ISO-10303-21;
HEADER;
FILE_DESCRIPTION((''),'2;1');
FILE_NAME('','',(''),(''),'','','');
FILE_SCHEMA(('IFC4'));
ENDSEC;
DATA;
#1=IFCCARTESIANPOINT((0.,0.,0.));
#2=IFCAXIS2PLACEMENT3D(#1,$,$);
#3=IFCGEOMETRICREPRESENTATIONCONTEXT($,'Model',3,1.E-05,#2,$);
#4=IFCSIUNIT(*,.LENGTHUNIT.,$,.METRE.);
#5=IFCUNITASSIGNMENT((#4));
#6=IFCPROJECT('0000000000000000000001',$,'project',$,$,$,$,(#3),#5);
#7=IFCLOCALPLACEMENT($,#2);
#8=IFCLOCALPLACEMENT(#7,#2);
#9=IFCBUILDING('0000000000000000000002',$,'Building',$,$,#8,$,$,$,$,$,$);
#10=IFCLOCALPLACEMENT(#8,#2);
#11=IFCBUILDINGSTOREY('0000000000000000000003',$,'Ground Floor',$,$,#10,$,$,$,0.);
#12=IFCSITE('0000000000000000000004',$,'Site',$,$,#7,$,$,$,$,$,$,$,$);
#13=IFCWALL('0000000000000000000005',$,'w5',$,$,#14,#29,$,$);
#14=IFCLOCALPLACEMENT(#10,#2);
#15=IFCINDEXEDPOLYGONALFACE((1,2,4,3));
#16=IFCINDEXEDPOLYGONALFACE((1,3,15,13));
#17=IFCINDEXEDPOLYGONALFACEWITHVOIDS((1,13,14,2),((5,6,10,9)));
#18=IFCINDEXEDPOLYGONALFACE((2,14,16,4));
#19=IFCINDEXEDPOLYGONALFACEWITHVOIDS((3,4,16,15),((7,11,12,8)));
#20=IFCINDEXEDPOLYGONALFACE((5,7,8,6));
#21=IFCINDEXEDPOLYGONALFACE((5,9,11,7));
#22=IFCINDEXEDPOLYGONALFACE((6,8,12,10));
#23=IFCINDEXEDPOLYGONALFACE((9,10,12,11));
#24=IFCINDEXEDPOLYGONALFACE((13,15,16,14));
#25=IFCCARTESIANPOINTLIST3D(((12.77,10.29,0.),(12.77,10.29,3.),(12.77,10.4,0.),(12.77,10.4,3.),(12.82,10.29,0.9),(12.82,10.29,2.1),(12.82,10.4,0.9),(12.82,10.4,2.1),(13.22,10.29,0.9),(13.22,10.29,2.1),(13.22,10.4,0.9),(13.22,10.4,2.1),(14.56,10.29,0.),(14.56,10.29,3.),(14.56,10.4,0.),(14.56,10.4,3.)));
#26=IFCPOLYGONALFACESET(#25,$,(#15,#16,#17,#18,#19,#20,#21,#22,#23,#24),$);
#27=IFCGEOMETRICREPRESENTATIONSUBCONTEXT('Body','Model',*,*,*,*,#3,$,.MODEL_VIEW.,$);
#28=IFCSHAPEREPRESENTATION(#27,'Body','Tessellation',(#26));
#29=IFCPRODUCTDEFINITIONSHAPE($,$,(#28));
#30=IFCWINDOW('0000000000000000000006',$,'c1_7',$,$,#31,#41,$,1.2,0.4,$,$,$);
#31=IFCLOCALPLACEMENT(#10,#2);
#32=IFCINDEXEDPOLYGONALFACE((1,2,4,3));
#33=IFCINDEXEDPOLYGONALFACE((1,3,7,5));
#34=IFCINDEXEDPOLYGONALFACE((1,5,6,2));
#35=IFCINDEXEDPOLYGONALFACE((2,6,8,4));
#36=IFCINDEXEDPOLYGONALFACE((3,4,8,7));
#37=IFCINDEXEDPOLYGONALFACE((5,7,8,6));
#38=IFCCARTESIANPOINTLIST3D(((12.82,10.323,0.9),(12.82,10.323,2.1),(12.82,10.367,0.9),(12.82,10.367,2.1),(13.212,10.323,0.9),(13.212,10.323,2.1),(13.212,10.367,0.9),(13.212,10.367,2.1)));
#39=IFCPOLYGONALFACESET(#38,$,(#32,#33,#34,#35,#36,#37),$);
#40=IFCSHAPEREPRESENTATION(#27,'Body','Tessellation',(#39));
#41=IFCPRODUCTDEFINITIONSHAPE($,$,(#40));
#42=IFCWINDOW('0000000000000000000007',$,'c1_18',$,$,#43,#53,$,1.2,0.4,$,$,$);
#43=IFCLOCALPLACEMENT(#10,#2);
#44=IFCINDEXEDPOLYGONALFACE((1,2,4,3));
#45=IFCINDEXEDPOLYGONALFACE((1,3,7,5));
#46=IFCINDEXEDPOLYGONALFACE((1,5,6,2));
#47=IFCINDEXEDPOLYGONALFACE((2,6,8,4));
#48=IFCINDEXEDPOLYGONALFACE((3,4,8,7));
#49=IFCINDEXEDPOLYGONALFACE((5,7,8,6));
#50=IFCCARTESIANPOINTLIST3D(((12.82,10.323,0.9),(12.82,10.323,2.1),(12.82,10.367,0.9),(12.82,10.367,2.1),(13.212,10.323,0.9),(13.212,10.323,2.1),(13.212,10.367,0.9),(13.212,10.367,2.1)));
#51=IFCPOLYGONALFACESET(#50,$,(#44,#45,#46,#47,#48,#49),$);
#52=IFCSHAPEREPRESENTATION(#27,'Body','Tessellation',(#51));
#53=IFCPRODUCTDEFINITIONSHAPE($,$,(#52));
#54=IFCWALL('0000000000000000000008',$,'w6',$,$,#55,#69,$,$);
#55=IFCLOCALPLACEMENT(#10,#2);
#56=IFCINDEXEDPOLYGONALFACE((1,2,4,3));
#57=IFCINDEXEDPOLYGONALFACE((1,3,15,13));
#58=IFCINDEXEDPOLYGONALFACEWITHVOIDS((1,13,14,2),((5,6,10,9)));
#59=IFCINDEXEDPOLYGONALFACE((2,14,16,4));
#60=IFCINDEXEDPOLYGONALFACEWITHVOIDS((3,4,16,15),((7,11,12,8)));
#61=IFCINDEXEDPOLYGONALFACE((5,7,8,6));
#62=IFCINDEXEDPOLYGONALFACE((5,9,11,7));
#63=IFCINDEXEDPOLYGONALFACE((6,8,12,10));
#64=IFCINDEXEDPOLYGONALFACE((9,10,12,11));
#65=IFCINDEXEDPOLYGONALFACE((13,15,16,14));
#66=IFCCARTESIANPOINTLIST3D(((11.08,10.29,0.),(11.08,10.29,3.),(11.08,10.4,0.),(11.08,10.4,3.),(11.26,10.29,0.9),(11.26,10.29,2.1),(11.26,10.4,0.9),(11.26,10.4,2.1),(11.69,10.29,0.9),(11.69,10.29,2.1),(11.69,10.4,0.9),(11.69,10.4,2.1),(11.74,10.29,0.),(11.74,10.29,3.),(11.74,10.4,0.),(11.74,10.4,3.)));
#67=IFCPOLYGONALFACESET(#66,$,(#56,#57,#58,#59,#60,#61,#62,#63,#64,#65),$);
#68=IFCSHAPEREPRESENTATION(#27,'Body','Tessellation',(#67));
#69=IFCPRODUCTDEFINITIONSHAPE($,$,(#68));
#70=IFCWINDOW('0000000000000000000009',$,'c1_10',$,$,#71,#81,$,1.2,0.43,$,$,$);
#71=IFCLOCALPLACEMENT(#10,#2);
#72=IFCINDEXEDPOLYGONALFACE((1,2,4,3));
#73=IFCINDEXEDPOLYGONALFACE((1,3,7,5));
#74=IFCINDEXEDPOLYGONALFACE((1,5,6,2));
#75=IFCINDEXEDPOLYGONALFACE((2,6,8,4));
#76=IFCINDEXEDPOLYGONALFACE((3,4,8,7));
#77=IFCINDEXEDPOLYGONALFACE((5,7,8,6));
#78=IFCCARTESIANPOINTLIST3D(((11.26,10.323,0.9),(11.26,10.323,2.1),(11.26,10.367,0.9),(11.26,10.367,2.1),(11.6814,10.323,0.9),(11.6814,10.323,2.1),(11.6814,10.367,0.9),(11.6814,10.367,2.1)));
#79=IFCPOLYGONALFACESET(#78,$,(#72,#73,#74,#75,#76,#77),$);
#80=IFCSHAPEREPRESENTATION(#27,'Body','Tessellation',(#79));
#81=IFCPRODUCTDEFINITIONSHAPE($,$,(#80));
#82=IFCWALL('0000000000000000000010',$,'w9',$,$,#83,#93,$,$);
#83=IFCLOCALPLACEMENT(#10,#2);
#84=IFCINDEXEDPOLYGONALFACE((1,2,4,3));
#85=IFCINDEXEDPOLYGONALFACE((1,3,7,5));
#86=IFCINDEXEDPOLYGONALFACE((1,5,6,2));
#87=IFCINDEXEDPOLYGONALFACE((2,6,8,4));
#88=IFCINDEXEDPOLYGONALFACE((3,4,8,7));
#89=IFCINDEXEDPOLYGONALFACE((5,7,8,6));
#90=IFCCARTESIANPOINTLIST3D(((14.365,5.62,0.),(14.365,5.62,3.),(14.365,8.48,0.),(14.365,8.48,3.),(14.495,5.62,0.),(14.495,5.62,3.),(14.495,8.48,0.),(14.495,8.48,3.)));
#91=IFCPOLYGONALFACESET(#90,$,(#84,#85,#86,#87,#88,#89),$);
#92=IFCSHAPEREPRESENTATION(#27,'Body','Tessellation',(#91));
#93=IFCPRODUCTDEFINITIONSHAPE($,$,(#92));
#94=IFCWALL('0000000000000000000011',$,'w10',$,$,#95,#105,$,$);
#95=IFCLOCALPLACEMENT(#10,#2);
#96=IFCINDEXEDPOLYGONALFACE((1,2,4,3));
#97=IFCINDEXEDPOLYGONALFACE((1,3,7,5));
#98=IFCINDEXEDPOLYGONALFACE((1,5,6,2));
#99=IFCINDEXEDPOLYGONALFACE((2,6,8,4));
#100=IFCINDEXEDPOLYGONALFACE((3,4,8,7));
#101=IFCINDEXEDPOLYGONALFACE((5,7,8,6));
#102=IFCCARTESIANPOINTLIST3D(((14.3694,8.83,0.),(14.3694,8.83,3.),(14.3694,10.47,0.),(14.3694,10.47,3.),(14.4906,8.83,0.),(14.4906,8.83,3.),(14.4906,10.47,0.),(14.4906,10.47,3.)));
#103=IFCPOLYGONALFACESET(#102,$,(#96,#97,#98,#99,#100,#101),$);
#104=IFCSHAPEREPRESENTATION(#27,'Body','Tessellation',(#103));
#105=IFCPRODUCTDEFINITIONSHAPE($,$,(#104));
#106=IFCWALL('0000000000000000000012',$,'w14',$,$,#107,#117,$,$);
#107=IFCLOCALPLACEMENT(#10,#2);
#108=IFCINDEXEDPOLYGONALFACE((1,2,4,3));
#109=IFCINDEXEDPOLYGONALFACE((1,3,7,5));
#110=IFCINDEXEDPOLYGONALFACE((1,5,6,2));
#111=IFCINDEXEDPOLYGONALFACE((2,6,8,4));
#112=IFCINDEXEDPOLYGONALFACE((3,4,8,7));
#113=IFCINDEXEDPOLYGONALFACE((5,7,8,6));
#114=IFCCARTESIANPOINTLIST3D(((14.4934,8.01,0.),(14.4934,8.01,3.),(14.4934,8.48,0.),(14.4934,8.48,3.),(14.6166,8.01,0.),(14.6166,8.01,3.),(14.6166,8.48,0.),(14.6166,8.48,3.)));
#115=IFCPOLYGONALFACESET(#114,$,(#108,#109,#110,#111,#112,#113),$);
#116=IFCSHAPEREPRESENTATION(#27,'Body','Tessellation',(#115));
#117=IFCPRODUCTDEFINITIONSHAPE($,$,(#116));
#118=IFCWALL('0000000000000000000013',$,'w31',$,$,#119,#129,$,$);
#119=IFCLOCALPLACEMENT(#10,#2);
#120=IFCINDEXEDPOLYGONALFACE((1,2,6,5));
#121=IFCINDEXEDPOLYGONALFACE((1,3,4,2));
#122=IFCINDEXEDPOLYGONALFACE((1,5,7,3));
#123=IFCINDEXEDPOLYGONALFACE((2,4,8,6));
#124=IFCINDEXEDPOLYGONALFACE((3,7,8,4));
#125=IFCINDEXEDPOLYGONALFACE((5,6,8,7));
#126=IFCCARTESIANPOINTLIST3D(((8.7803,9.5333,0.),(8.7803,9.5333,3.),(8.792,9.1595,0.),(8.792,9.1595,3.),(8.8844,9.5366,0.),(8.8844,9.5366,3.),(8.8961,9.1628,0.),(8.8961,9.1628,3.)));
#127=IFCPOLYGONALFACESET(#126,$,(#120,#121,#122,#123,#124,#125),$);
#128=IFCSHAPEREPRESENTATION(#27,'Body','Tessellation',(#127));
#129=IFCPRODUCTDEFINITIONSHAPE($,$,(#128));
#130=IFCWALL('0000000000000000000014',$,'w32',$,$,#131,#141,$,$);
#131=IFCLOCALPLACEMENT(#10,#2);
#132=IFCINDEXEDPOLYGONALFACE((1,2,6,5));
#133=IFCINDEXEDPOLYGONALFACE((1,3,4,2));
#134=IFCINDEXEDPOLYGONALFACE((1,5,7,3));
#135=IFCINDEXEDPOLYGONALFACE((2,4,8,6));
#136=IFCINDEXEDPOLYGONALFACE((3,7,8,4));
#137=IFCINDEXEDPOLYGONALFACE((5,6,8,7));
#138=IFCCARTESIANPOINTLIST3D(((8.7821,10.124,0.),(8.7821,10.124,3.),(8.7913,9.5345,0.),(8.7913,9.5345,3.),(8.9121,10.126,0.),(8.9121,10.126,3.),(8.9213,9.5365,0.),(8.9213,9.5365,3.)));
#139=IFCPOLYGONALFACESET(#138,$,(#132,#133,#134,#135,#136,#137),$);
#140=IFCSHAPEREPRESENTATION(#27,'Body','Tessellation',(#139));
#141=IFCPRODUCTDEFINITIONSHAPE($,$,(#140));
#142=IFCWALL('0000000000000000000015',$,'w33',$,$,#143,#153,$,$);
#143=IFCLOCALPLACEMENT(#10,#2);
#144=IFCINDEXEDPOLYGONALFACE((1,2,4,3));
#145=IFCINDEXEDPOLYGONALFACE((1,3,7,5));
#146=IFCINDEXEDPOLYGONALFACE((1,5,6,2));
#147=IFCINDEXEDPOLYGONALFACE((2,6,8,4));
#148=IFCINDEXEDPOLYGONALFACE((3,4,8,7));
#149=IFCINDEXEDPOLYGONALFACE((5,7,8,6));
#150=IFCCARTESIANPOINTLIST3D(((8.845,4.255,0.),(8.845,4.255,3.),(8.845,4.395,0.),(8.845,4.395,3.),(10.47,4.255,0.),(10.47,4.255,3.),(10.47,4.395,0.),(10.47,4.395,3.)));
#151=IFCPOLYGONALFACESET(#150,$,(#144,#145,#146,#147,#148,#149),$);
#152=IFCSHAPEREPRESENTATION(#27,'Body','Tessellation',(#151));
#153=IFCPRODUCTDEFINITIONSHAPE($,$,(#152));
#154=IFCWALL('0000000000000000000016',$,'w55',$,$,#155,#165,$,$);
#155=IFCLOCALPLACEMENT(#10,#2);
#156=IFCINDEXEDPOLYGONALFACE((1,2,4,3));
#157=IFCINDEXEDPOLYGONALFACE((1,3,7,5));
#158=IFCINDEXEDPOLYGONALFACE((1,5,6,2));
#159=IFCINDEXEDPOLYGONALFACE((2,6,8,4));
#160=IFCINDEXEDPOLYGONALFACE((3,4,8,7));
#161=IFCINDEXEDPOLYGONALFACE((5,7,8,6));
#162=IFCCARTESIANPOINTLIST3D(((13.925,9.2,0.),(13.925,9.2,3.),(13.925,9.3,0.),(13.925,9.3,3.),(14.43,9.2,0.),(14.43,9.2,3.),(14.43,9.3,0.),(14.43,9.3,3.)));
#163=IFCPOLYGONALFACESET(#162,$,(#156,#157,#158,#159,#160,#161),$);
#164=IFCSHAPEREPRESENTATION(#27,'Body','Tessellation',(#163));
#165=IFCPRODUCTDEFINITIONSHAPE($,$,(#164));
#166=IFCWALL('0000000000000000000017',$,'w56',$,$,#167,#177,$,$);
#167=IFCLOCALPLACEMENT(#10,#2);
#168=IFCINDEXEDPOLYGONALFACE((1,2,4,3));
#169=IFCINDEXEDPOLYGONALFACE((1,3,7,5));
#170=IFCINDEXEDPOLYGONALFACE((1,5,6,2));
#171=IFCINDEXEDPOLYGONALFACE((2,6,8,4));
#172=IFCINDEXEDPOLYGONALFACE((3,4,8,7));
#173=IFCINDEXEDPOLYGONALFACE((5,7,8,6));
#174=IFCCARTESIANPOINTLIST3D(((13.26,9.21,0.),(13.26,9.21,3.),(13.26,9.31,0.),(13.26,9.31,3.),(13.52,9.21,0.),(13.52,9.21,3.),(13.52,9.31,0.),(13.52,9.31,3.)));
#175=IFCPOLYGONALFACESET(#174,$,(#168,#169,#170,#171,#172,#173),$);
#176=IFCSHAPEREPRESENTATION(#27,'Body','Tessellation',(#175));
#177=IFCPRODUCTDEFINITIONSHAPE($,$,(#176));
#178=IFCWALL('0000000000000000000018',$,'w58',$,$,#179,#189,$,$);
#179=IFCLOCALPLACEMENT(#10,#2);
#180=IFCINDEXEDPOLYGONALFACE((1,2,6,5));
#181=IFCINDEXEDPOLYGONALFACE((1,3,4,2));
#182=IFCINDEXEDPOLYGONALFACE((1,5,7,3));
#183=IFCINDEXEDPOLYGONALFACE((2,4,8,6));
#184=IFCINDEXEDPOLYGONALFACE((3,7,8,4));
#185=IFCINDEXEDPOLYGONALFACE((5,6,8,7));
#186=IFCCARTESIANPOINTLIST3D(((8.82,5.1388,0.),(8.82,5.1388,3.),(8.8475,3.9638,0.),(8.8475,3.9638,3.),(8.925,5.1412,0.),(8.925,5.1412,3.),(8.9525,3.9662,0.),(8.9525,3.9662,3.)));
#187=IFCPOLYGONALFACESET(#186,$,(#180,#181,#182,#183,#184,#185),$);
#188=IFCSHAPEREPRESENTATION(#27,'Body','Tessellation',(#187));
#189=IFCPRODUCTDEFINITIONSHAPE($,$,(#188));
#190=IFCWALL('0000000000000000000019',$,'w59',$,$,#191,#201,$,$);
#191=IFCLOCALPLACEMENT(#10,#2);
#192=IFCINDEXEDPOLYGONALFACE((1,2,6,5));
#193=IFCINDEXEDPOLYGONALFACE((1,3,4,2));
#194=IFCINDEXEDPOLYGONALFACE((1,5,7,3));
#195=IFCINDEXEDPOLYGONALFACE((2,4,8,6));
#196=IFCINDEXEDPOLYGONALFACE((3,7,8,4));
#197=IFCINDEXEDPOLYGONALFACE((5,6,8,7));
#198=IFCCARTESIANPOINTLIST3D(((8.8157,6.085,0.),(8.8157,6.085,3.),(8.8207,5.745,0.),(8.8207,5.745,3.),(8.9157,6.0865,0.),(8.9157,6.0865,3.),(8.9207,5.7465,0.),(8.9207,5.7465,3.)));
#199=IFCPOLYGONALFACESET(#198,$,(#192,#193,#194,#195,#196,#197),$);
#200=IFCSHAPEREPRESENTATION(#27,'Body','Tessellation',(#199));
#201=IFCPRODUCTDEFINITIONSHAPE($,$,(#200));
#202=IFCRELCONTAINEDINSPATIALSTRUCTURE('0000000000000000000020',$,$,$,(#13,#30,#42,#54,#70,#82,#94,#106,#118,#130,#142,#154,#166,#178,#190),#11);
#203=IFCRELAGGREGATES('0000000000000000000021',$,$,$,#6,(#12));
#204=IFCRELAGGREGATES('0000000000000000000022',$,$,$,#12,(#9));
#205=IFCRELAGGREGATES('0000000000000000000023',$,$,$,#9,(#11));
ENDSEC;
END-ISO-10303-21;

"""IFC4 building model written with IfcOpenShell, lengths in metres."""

from ifc_helpers import new_model, si_unit, frame, origin, place, context, subcontext, project, spatial, polyline, outline, extrude, element, fill, save


model = new_model("IFC4")

# Units and contexts
model_context = context("Model", 3, precision=1e-05, world=origin())
body_context = subcontext(model_context, "Body", "Model", "MODEL_VIEW")
ifc_project = project(units=[si_unit("LENGTHUNIT", "METRE")], contexts=[model_context])

# Site, building, storey
site_placement = place(None, origin())
site = spatial("IfcSite", under=ifc_project, at=site_placement, Name="Site")
building_placement = place(site_placement, origin())
building = spatial("IfcBuilding", under=site, at=building_placement, Name="Building")
storey_placement = place(building_placement, origin())
storey = spatial("IfcBuildingStorey", under=building, at=storey_placement, Name="Ground Floor", Elevation=0.0)

# Wall, openings, windows
wall_1_placement = place(storey_placement, frame((12.77, 10.345, 0.0), x_axis=(1.0, 0.0, 0.0)))
wall_1 = element("IfcWall", 1, at=wall_1_placement, inside=storey, Name="w5", context=body_context, shape_type="SweptSolid", body=[
    extrude(outline(polyline([(0.0, -0.055), (1.79, -0.055), (1.79, 0.055), (0.0, 0.055), (0.0, -0.055)])), origin(), (0.0, 0.0, 1.0), 3.0),
])
opening_1_placement = place(wall_1_placement, frame((0.05, 0.0, 0.0)))
opening_1 = element("IfcOpeningElement", 2, at=opening_1_placement, cuts=wall_1, context=body_context, shape_type="SweptSolid", body=[
    extrude(outline(polyline([(0.0, -0.0577), (0.4, -0.0577), (0.4, 0.0577), (0.0, 0.0577), (0.0, -0.0577)])), frame((0.0, 0.0, 0.9)), (0.0, 0.0, 1.0), 1.2),
])
opening_2_placement = place(wall_1_placement, frame((0.05, 0.0, 0.0)))
opening_2 = element("IfcOpeningElement", 3, at=opening_2_placement, cuts=wall_1, context=body_context, shape_type="SweptSolid", body=[
    extrude(outline(polyline([(0.0, -0.0577), (0.4, -0.0577), (0.4, 0.0577), (0.0, 0.0577), (0.0, -0.0577)])), frame((0.0, 0.0, 0.9)), (0.0, 0.0, 1.0), 1.2),
])
window_1_placement = place(wall_1_placement, frame((0.05, 0.0, 0.0)))
window_1 = element("IfcWindow", 4, at=window_1_placement, inside=storey, Name="c1_7", OverallHeight=1.2, OverallWidth=0.4, context=body_context, shape_type="SweptSolid", body=[
    extrude(outline(polyline([(0.0, -0.022), (0.392, -0.022), (0.392, 0.022), (0.0, 0.022), (0.0, -0.022)])), frame((0.0, 0.0, 0.9)), (0.0, 0.0, 1.0), 1.2),
])
fill(opening_1, window_1)
window_2_placement = place(wall_1_placement, frame((0.05, 0.0, 0.0)))
window_2 = element("IfcWindow", 5, at=window_2_placement, inside=storey, Name="c1_18", OverallHeight=1.2, OverallWidth=0.4, context=body_context, shape_type="SweptSolid", body=[
    extrude(outline(polyline([(0.0, -0.022), (0.392, -0.022), (0.392, 0.022), (0.0, 0.022), (0.0, -0.022)])), frame((0.0, 0.0, 0.9)), (0.0, 0.0, 1.0), 1.2),
])
fill(opening_2, window_2)

# Wall, opening, window
wall_2_placement = place(storey_placement, frame((11.08, 10.345, 0.0), x_axis=(1.0, 0.0, 0.0)))
wall_2 = element("IfcWall", 6, at=wall_2_placement, inside=storey, Name="w6", context=body_context, shape_type="SweptSolid", body=[
    extrude(outline(polyline([(0.0, -0.055), (0.66, -0.055), (0.66, 0.055), (0.0, 0.055), (0.0, -0.055)])), origin(), (0.0, 0.0, 1.0), 3.0),
])
opening_3_placement = place(wall_2_placement, frame((0.18, 0.0, 0.0)))
opening_3 = element("IfcOpeningElement", 7, at=opening_3_placement, cuts=wall_2, context=body_context, shape_type="SweptSolid", body=[
    extrude(outline(polyline([(0.0, -0.0577), (0.43, -0.0577), (0.43, 0.0577), (0.0, 0.0577), (0.0, -0.0577)])), frame((0.0, 0.0, 0.9)), (0.0, 0.0, 1.0), 1.2),
])
window_3_placement = place(wall_2_placement, frame((0.18, 0.0, 0.0)))
window_3 = element("IfcWindow", 8, at=window_3_placement, inside=storey, Name="c1_10", OverallHeight=1.2, OverallWidth=0.43, context=body_context, shape_type="SweptSolid", body=[
    extrude(outline(polyline([(0.0, -0.022), (0.4214, -0.022), (0.4214, 0.022), (0.0, 0.022), (0.0, -0.022)])), frame((0.0, 0.0, 0.9)), (0.0, 0.0, 1.0), 1.2),
])
fill(opening_3, window_3)

# Walls
wall_3_placement = place(storey_placement, frame((14.43, 5.62, 0.0), x_axis=(0.0, 1.0, 0.0)))
element("IfcWall", 9, at=wall_3_placement, inside=storey, Name="w9", context=body_context, shape_type="SweptSolid", body=[
    extrude(outline(polyline([(0.0, -0.065), (2.86, -0.065), (2.86, 0.065), (0.0, 0.065), (0.0, -0.065)])), origin(), (0.0, 0.0, 1.0), 3.0),
])
wall_4_placement = place(storey_placement, frame((14.43, 8.83, 0.0), x_axis=(0.0, 1.0, 0.0)))
element("IfcWall", 10, at=wall_4_placement, inside=storey, Name="w10", context=body_context, shape_type="SweptSolid", body=[
    extrude(outline(polyline([(0.0, -0.0606), (1.64, -0.0606), (1.64, 0.0606), (0.0, 0.0606), (0.0, -0.0606)])), origin(), (0.0, 0.0, 1.0), 3.0),
])
wall_5_placement = place(storey_placement, frame((14.555, 8.01, 0.0), x_axis=(0.0, 1.0, 0.0)))
element("IfcWall", 11, at=wall_5_placement, inside=storey, Name="w14", context=body_context, shape_type="SweptSolid", body=[
    extrude(outline(polyline([(0.0, -0.0616), (0.47, -0.0616), (0.47, 0.0616), (0.0, 0.0616), (0.0, -0.0616)])), origin(), (0.0, 0.0, 1.0), 3.0),
])
wall_6_placement = place(storey_placement, frame((8.8323, 9.535, 0.0), x_axis=(0.031229, -0.999512, 0.0)))
element("IfcWall", 12, at=wall_6_placement, inside=storey, Name="w31", context=body_context, shape_type="SweptSolid", body=[
    extrude(outline(polyline([(0.0, -0.0521), (0.374, -0.0521), (0.374, 0.0521), (0.0, 0.0521), (0.0, -0.0521)])), origin(), (0.0, 0.0, 1.0), 3.0),
])
wall_7_placement = place(storey_placement, frame((8.8471, 10.125, 0.0), x_axis=(0.01562, -0.999878, 0.0)))
element("IfcWall", 13, at=wall_7_placement, inside=storey, Name="w32", context=body_context, shape_type="SweptSolid", body=[
    extrude(outline(polyline([(0.0, -0.065), (0.5895, -0.065), (0.5895, 0.065), (0.0, 0.065), (0.0, -0.065)])), origin(), (0.0, 0.0, 1.0), 3.0),
])
wall_8_placement = place(storey_placement, frame((8.845, 4.325, 0.0), x_axis=(1.0, 0.0, 0.0)))
element("IfcWall", 14, at=wall_8_placement, inside=storey, Name="w33", context=body_context, shape_type="SweptSolid", body=[
    extrude(outline(polyline([(0.0, -0.07), (1.625, -0.07), (1.625, 0.07), (0.0, 0.07), (0.0, -0.07)])), origin(), (0.0, 0.0, 1.0), 3.0),
])
wall_9_placement = place(storey_placement, frame((13.925, 9.25, 0.0), x_axis=(1.0, 0.0, 0.0)))
element("IfcWall", 15, at=wall_9_placement, inside=storey, Name="w55", context=body_context, shape_type="SweptSolid", body=[
    extrude(outline(polyline([(0.0, -0.05), (0.505, -0.05), (0.505, 0.05), (0.0, 0.05), (0.0, -0.05)])), origin(), (0.0, 0.0, 1.0), 3.0),
])
wall_10_placement = place(storey_placement, frame((13.26, 9.26, 0.0), x_axis=(1.0, 0.0, 0.0)))
element("IfcWall", 16, at=wall_10_placement, inside=storey, Name="w56", context=body_context, shape_type="SweptSolid", body=[
    extrude(outline(polyline([(0.0, -0.05), (0.26, -0.05), (0.26, 0.05), (0.0, 0.05), (0.0, -0.05)])), origin(), (0.0, 0.0, 1.0), 3.0),
])
wall_11_placement = place(storey_placement, frame((8.9, 3.965, 0.0), x_axis=(-0.023396, 0.999726, 0.0)))
element("IfcWall", 17, at=wall_11_placement, inside=storey, Name="w58", context=body_context, shape_type="SweptSolid", body=[
    extrude(outline(polyline([(0.0, -0.0525), (1.1753, -0.0525), (1.1753, 0.0525), (0.0, 0.0525), (0.0, -0.0525)])), origin(), (0.0, 0.0, 1.0), 3.0),
])
wall_12_placement = place(storey_placement, frame((8.8707, 5.7457, 0.0), x_axis=(-0.014702, 0.999892, 0.0)))
element("IfcWall", 18, at=wall_12_placement, inside=storey, Name="w59", context=body_context, shape_type="SweptSolid", body=[
    extrude(outline(polyline([(0.0, -0.05), (0.34, -0.05), (0.34, 0.05), (0.0, 0.05), (0.0, -0.05)])), origin(), (0.0, 0.0, 1.0), 3.0),
])

save(model, "model.ifc")
